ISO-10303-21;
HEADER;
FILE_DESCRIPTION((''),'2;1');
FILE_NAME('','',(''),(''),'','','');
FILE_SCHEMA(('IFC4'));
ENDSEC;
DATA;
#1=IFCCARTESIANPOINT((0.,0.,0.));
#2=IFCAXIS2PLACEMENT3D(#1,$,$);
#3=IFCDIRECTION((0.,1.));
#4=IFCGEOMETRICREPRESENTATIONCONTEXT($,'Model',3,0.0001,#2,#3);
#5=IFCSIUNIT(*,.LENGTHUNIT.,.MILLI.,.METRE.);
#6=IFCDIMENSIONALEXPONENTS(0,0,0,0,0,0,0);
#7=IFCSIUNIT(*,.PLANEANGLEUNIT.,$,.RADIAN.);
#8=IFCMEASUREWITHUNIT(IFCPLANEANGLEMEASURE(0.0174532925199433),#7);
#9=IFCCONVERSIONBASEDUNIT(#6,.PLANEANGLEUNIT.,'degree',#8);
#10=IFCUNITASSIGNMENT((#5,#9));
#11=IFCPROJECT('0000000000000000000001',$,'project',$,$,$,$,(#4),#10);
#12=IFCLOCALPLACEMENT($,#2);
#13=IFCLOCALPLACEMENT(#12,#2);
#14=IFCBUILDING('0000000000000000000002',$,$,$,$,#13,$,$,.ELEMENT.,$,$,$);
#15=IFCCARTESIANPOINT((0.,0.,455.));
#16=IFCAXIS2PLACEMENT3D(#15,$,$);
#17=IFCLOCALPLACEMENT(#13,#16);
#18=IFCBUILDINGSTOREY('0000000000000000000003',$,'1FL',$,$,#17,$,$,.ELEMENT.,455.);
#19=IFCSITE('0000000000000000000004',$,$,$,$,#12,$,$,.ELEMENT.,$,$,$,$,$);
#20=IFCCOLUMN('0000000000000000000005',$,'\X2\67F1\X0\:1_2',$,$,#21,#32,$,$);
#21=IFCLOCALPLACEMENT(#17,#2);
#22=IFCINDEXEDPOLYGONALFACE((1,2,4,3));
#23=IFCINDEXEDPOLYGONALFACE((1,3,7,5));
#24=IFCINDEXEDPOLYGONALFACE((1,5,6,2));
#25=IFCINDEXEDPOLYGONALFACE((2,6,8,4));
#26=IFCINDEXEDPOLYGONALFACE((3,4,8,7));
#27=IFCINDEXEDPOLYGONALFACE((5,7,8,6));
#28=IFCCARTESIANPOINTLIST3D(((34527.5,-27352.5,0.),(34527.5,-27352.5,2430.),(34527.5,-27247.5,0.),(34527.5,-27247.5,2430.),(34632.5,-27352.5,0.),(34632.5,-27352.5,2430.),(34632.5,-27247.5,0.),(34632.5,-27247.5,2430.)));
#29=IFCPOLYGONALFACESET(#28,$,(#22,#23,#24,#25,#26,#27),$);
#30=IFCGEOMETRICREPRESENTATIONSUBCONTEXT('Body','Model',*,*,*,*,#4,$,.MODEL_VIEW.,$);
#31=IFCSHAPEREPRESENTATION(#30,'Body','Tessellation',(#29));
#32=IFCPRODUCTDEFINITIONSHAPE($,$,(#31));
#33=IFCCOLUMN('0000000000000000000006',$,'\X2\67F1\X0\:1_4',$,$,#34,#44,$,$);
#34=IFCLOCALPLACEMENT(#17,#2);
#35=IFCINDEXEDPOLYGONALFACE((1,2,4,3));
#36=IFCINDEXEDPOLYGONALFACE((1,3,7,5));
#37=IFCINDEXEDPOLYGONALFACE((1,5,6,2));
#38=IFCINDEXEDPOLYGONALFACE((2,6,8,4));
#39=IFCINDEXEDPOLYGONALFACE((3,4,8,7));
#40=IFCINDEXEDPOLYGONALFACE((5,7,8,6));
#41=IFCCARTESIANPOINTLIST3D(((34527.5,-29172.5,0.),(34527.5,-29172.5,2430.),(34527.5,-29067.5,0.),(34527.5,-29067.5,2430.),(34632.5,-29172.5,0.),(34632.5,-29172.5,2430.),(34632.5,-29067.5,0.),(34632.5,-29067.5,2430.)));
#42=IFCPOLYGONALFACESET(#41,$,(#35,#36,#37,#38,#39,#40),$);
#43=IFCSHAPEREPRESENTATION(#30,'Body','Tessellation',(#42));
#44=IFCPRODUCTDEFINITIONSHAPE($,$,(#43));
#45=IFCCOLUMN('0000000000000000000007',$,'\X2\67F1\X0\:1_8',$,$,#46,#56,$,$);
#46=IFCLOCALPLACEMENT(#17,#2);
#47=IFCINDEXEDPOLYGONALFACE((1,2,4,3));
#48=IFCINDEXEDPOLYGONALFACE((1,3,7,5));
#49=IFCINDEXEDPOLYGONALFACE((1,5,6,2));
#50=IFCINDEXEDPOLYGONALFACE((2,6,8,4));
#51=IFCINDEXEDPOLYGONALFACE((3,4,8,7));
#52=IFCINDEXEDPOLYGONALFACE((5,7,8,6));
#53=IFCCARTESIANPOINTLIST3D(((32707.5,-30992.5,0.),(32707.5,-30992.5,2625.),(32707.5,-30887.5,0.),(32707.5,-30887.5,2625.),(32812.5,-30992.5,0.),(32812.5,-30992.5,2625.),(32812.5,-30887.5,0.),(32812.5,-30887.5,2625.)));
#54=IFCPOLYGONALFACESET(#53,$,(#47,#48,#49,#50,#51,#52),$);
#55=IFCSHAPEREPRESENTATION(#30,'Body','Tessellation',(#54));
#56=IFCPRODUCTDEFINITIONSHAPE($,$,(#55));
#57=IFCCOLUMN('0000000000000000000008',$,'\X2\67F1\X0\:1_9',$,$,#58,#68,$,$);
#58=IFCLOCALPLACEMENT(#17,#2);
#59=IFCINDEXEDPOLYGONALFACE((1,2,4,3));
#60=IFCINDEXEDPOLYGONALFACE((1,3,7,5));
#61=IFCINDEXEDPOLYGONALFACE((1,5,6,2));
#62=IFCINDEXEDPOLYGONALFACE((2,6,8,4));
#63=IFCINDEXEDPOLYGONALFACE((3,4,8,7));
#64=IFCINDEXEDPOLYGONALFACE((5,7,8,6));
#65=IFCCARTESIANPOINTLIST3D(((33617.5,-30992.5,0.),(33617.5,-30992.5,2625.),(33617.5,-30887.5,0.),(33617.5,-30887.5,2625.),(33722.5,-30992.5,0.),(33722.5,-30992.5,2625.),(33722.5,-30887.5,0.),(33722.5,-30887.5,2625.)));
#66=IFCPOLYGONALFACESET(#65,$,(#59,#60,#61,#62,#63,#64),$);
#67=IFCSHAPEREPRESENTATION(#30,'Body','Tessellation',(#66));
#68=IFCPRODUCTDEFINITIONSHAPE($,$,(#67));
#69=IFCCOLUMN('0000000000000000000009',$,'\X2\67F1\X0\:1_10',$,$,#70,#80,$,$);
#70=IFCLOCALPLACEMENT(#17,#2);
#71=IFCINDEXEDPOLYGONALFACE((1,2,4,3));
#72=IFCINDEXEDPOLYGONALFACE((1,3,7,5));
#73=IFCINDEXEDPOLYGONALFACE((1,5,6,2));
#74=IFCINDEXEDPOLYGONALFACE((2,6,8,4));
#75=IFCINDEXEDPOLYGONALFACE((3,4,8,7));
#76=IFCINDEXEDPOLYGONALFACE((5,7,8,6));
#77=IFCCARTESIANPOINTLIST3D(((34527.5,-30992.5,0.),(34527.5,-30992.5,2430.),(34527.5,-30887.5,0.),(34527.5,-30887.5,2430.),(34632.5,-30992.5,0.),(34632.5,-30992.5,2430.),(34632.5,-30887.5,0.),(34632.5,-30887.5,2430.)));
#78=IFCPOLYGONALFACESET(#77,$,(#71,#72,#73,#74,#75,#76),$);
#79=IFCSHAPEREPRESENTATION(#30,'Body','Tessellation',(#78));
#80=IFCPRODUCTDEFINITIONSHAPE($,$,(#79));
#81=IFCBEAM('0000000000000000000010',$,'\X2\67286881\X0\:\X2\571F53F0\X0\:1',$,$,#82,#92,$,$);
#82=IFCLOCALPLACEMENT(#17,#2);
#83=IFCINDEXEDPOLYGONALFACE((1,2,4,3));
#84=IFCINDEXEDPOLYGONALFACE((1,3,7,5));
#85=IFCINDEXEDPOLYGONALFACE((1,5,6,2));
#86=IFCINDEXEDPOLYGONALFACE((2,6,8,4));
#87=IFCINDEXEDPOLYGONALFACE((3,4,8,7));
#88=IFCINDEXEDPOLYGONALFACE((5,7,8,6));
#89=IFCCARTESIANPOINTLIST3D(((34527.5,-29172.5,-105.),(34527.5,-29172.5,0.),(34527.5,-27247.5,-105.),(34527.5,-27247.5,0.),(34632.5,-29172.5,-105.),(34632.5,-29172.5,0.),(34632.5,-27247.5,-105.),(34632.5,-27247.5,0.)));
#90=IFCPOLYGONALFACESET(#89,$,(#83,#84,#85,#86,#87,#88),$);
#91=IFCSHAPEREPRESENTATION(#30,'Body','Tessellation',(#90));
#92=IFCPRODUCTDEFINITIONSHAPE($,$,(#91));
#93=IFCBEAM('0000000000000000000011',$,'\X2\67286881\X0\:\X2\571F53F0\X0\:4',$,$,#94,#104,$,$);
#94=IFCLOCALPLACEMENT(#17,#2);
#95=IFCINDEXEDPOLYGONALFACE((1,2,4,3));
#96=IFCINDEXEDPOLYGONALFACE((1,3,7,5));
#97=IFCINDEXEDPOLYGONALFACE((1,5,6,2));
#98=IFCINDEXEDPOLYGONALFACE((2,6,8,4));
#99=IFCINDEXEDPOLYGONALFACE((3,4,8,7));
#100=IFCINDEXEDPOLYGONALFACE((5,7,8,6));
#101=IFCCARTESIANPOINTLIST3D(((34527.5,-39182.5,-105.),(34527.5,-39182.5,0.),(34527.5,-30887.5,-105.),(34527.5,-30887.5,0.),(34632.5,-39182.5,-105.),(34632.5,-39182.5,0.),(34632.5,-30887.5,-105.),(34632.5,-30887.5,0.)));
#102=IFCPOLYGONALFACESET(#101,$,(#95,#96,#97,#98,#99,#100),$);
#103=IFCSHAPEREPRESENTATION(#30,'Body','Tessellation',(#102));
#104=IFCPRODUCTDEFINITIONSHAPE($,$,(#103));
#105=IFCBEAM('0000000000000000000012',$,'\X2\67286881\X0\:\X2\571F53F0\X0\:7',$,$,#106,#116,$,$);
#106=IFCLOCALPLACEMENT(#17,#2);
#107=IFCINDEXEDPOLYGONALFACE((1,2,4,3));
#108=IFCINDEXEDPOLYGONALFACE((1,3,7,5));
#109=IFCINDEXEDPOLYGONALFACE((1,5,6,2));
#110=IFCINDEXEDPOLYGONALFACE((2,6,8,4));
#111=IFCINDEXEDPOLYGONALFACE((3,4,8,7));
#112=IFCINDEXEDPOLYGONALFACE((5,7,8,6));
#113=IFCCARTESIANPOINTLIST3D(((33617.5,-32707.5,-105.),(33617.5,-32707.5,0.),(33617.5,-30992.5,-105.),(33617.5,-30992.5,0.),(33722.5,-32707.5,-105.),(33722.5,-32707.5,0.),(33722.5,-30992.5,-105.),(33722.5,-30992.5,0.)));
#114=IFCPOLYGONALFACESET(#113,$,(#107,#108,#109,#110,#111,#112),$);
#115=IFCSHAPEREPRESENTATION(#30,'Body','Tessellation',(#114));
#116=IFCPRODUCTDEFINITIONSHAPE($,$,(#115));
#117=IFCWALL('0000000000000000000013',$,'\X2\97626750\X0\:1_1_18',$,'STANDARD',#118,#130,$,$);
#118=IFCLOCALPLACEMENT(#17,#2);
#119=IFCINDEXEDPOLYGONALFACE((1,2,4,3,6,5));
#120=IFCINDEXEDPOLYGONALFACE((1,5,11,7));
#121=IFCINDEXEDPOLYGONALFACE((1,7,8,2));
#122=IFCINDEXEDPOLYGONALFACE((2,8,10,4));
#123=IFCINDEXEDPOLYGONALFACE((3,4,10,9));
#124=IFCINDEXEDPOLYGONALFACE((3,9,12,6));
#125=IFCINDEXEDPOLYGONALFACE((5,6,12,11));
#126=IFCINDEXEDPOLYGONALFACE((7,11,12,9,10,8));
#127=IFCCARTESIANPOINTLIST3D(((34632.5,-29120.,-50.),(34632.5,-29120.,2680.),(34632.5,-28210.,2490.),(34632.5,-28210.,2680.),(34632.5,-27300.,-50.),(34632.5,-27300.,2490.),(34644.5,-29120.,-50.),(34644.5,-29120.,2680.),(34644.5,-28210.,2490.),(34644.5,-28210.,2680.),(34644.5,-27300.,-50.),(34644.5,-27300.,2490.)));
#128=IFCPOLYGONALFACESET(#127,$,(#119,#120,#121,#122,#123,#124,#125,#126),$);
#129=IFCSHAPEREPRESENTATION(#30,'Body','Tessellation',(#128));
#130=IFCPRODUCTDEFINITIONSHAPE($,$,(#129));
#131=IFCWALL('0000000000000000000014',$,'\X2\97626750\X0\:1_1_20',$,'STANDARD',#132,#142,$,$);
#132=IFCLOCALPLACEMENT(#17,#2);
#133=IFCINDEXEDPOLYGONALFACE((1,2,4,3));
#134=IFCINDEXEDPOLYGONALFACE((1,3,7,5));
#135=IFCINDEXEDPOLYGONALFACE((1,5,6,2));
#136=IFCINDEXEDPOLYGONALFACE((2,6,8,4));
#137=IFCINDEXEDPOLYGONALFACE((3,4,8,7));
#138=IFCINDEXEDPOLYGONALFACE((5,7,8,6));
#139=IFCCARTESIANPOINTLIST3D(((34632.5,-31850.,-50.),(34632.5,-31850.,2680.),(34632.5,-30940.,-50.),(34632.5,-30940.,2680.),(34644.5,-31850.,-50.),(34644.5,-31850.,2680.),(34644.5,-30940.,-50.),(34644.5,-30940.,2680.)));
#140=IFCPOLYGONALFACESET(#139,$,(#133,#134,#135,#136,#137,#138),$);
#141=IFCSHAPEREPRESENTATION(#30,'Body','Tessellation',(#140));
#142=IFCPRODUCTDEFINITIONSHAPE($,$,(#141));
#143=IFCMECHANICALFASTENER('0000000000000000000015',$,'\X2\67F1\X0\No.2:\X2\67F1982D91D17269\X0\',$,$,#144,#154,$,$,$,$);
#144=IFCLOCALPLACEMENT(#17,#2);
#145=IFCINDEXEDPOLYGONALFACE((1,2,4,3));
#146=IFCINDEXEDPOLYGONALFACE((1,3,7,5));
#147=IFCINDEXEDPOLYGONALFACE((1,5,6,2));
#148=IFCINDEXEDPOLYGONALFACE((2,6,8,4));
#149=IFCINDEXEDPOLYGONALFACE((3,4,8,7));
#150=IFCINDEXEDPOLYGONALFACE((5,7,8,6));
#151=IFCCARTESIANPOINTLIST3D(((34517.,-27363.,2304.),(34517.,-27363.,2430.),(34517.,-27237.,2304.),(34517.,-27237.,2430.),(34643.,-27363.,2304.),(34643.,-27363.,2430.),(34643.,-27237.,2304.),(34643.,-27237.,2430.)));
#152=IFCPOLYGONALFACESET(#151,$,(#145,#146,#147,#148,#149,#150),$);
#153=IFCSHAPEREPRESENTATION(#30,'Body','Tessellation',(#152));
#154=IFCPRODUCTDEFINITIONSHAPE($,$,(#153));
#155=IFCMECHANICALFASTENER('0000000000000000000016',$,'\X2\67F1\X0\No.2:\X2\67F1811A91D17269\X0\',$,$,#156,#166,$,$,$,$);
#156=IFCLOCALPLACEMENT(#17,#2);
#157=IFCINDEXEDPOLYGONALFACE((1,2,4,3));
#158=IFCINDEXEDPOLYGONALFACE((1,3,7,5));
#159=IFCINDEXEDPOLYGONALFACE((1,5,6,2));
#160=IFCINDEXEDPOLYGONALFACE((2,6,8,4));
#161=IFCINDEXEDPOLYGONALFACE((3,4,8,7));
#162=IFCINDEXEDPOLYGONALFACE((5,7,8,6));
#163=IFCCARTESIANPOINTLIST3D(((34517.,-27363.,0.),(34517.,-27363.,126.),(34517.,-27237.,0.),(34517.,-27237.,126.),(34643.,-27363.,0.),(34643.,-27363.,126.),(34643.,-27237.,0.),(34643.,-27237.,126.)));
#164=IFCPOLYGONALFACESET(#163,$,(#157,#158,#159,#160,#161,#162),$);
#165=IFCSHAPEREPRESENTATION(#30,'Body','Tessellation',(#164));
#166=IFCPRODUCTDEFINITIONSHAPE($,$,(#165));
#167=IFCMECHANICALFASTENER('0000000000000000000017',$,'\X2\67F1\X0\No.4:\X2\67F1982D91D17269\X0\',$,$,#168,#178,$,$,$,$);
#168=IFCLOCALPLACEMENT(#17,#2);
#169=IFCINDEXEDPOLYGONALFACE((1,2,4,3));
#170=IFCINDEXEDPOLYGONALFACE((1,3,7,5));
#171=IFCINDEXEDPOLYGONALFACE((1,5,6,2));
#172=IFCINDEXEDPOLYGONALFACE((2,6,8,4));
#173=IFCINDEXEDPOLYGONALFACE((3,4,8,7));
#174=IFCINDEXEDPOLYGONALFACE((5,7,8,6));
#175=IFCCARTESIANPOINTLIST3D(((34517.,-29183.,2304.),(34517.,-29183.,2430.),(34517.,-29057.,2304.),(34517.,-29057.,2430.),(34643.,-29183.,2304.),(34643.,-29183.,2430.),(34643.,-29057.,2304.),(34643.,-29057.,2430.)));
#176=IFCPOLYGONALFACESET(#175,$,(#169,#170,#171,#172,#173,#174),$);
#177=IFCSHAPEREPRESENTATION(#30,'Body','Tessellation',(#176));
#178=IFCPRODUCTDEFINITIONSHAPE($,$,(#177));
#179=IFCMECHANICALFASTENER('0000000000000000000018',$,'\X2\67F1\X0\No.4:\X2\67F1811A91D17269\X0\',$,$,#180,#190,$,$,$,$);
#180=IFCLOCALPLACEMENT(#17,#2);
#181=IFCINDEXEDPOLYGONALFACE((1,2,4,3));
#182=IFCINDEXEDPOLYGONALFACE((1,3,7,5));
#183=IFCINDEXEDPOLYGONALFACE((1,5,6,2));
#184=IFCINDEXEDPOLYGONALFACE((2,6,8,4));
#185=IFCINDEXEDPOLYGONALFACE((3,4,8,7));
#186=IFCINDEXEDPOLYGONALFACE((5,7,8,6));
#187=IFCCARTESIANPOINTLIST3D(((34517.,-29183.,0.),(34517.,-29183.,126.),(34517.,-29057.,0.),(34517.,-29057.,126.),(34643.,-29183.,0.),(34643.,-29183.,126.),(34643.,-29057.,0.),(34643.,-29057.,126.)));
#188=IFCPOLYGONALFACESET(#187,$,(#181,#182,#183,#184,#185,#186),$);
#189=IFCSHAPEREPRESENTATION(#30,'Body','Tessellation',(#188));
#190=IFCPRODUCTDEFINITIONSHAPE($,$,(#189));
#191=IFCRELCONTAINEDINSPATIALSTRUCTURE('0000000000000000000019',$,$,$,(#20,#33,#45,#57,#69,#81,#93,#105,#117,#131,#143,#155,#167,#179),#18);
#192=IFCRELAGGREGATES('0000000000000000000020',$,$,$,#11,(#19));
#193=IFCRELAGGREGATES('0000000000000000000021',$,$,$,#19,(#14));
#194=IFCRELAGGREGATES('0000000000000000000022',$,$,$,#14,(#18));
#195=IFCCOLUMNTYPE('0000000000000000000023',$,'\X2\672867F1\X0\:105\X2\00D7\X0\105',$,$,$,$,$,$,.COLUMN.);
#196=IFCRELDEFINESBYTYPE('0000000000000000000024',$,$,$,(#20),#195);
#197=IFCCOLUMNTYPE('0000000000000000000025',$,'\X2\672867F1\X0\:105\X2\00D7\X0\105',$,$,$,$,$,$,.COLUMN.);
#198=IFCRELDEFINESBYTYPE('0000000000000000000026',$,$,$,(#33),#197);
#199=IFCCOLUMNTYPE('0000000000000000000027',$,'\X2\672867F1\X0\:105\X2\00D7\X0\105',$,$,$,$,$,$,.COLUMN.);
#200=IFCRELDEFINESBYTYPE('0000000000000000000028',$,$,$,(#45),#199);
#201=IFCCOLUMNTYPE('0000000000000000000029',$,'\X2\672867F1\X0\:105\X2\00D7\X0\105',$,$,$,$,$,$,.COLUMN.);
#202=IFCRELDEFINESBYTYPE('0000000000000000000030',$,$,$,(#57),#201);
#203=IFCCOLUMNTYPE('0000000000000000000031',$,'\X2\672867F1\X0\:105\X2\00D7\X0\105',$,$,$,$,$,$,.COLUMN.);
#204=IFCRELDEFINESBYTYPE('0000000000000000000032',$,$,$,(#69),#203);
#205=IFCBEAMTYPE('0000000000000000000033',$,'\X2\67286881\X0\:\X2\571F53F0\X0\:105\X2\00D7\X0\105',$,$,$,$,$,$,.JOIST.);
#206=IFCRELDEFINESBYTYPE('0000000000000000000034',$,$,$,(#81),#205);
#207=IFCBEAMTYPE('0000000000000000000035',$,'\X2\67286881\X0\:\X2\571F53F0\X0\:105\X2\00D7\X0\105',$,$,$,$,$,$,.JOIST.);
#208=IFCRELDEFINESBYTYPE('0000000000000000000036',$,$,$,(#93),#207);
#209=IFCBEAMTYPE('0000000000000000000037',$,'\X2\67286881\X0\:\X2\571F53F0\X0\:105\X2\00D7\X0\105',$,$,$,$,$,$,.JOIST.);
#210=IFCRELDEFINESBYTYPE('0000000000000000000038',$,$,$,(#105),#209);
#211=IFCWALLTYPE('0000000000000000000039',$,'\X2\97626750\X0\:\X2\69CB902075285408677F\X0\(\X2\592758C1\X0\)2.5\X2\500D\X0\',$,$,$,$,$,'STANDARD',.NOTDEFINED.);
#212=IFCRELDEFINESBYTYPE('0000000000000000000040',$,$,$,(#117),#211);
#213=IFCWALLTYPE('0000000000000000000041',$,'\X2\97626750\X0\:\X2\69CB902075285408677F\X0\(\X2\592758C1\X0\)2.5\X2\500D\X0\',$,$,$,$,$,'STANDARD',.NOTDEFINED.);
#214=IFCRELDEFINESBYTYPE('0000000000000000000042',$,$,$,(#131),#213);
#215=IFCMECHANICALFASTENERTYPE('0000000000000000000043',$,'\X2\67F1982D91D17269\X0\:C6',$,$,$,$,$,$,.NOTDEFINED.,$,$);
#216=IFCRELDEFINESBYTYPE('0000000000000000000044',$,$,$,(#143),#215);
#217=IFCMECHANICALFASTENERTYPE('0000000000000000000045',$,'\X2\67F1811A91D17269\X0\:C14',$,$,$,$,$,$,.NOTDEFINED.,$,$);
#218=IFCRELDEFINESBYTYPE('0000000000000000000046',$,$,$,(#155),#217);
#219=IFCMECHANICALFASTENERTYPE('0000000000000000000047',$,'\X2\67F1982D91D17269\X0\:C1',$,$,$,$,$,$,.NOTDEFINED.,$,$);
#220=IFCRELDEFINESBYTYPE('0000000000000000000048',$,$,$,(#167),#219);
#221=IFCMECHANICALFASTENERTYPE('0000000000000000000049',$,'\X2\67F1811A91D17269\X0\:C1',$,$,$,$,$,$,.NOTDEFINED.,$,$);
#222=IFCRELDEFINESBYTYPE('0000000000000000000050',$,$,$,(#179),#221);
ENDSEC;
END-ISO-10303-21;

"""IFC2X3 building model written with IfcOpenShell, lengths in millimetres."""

from ifc_helpers import new_model, entity, si_unit, converted_unit, direction, frame, origin, origin_with_axes, origin_2d, place, context, subcontext, project, spatial, polyline, rectangle, outline, extrude, type_object, element, save


model = new_model("IFC2X3")

# Units and contexts
model_context = context("Model", 3, precision=0.0001, world=origin(), true_north=direction((0.0, 1.0)))
body_context = subcontext(model_context, "Body", "Model", "MODEL_VIEW")
ifc_project = project(units=[si_unit("LENGTHUNIT", "METRE", prefix="MILLI"), converted_unit("PLANEANGLEUNIT", "degree", entity("IfcPlaneAngleMeasure", 0.0174532925199433), si_unit("PLANEANGLEUNIT", "RADIAN"), dimensions=[0, 0, 0, 0, 0, 0, 0])], contexts=[model_context])

# Site, building, storey
site_placement = place(None, origin())
site = spatial("IfcSite", under=ifc_project, at=site_placement, CompositionType="ELEMENT")
building_placement = place(site_placement, origin())
building = spatial("IfcBuilding", under=site, at=building_placement, CompositionType="ELEMENT")
storey_placement = place(building_placement, frame((0.0, 0.0, 455.0)))
storey = spatial("IfcBuildingStorey", under=building, at=storey_placement, Name="1FL", CompositionType="ELEMENT", Elevation=455.0)

# Columns
column_type_1 = type_object("IfcColumnType", Name="木柱:105×105", PredefinedType="COLUMN")
column_1_placement = place(storey_placement, frame((34580.0, -27300.0, 0.0)))
element("IfcColumn", 1, at=column_1_placement, inside=storey, type_object=column_type_1, Name="柱:1_2", context=body_context, shape_type="SweptSolid", body=[
    extrude(rectangle(XDim=105.0, YDim=105.0, at=origin_2d()), origin_with_axes(), (0.0, 0.0, 1.0), 2430.0),
])
column_type_2 = type_object("IfcColumnType", Name="木柱:105×105", PredefinedType="COLUMN")
column_2_placement = place(storey_placement, frame((34580.0, -29120.0, 0.0)))
element("IfcColumn", 2, at=column_2_placement, inside=storey, type_object=column_type_2, Name="柱:1_4", context=body_context, shape_type="SweptSolid", body=[
    extrude(rectangle(XDim=105.0, YDim=105.0, at=origin_2d()), origin_with_axes(), (0.0, 0.0, 1.0), 2430.0),
])
column_type_3 = type_object("IfcColumnType", Name="木柱:105×105", PredefinedType="COLUMN")
column_3_placement = place(storey_placement, frame((32760.0, -30940.0, 0.0)))
element("IfcColumn", 3, at=column_3_placement, inside=storey, type_object=column_type_3, Name="柱:1_8", context=body_context, shape_type="SweptSolid", body=[
    extrude(rectangle(XDim=105.0, YDim=105.0, at=origin_2d()), origin_with_axes(), (0.0, 0.0, 1.0), 2625.0),
])
column_type_4 = type_object("IfcColumnType", Name="木柱:105×105", PredefinedType="COLUMN")
column_4_placement = place(storey_placement, frame((33670.0, -30940.0, 0.0)))
element("IfcColumn", 4, at=column_4_placement, inside=storey, type_object=column_type_4, Name="柱:1_9", context=body_context, shape_type="SweptSolid", body=[
    extrude(rectangle(XDim=105.0, YDim=105.0, at=origin_2d()), origin_with_axes(), (0.0, 0.0, 1.0), 2625.0),
])
column_type_5 = type_object("IfcColumnType", Name="木柱:105×105", PredefinedType="COLUMN")
column_5_placement = place(storey_placement, frame((34580.0, -30940.0, 0.0)))
element("IfcColumn", 5, at=column_5_placement, inside=storey, type_object=column_type_5, Name="柱:1_10", context=body_context, shape_type="SweptSolid", body=[
    extrude(rectangle(XDim=105.0, YDim=105.0, at=origin_2d()), origin_with_axes(), (0.0, 0.0, 1.0), 2430.0),
])

# Beams
beam_type_1 = type_object("IfcBeamType", Name="木梁:土台:105×105", PredefinedType="JOIST")
beam_1_placement = place(storey_placement, frame((34580.0, -27247.5, -52.5), z_axis=(0.0, -1.0, 0.0), x_axis=(1.0, 0.0, 0.0)))
element("IfcBeam", 6, at=beam_1_placement, inside=storey, type_object=beam_type_1, Name="木梁:土台:1", context=body_context, shape_type="SweptSolid", body=[
    extrude(rectangle(XDim=105.0, YDim=105.0, at=origin_2d()), origin_with_axes(), (0.0, 0.0, 1.0), 1925.0),
])
beam_type_2 = type_object("IfcBeamType", Name="木梁:土台:105×105", PredefinedType="JOIST")
beam_2_placement = place(storey_placement, frame((34580.0, -30887.5, -52.5), z_axis=(0.0, -1.0, 0.0), x_axis=(1.0, 0.0, 0.0)))
element("IfcBeam", 7, at=beam_2_placement, inside=storey, type_object=beam_type_2, Name="木梁:土台:4", context=body_context, shape_type="SweptSolid", body=[
    extrude(rectangle(XDim=105.0, YDim=105.0, at=origin_2d()), origin_with_axes(), (0.0, 0.0, 1.0), 8295.0),
])
beam_type_3 = type_object("IfcBeamType", Name="木梁:土台:105×105", PredefinedType="JOIST")
beam_3_placement = place(storey_placement, frame((33670.0, -30992.5, -52.5), z_axis=(0.0, -1.0, 0.0), x_axis=(1.0, 0.0, 0.0)))
element("IfcBeam", 8, at=beam_3_placement, inside=storey, type_object=beam_type_3, Name="木梁:土台:7", context=body_context, shape_type="SweptSolid", body=[
    extrude(rectangle(XDim=105.0, YDim=105.0, at=origin_2d()), origin_with_axes(), (0.0, 0.0, 1.0), 1715.0),
])

# Walls
wall_type_1 = type_object("IfcWallType", Name="面材:構造用合板(大壁)2.5倍", ElementType="STANDARD", PredefinedType="NOTDEFINED")
wall_1_placement = place(storey_placement, frame((34644.5, -28210.0, -50.0), z_axis=(-1.0, 0.0, 0.0), x_axis=(0.0, -1.0, 0.0)))
element("IfcWall", 9, at=wall_1_placement, inside=storey, type_object=wall_type_1, Name="面材:1_1_18", ObjectType="STANDARD", context=body_context, shape_type="SweptSolid", body=[
    extrude(outline(polyline([(910.0, 0.0, 0.0), (-910.0, 0.0, 0.0), (-910.0, 2540.0, 0.0), (0.0, 2540.0, 0.0), (0.0, 2730.0, 0.0), (910.0, 2730.0, 0.0), (910.0, 0.0, 0.0)])), origin_with_axes(), (0.0, 0.0, 1.0), 12.0),
])
wall_type_2 = type_object("IfcWallType", Name="面材:構造用合板(大壁)2.5倍", ElementType="STANDARD", PredefinedType="NOTDEFINED")
wall_2_placement = place(storey_placement, frame((34644.5, -31395.0, -50.0), z_axis=(-1.0, 0.0, 0.0), x_axis=(0.0, -1.0, 0.0)))
element("IfcWall", 10, at=wall_2_placement, inside=storey, type_object=wall_type_2, Name="面材:1_1_20", ObjectType="STANDARD", context=body_context, shape_type="SweptSolid", body=[
    extrude(outline(polyline([(455.0, 0.0, 0.0), (-455.0, 0.0, 0.0), (-455.0, 2730.0, 0.0), (455.0, 2730.0, 0.0), (455.0, 0.0, 0.0)])), origin_with_axes(), (0.0, 0.0, 1.0), 12.0),
])

# Mechanical fasteners
mechanical_fastener_type_1 = type_object("IfcMechanicalFastenerType", Name="柱頭金物:C6")
mechanical_fastener_1_placement = place(storey_placement, frame((34580.0, -27300.0, 2304.0)))
element("IfcMechanicalFastener", 11, at=mechanical_fastener_1_placement, inside=storey, type_object=mechanical_fastener_type_1, Name="柱No.2:柱頭金物", context=body_context, shape_type="SweptSolid", body=[
    extrude(rectangle(XDim=126.0, YDim=126.0, at=origin_2d()), origin_with_axes(), (0.0, 0.0, 1.0), 126.0),
])
mechanical_fastener_type_2 = type_object("IfcMechanicalFastenerType", Name="柱脚金物:C14")
mechanical_fastener_2_placement = place(storey_placement, frame((34580.0, -27300.0, 0.0)))
element("IfcMechanicalFastener", 12, at=mechanical_fastener_2_placement, inside=storey, type_object=mechanical_fastener_type_2, Name="柱No.2:柱脚金物", context=body_context, shape_type="SweptSolid", body=[
    extrude(rectangle(XDim=126.0, YDim=126.0, at=origin_2d()), origin_with_axes(), (0.0, 0.0, 1.0), 126.0),
])
mechanical_fastener_type_3 = type_object("IfcMechanicalFastenerType", Name="柱頭金物:C1")
mechanical_fastener_3_placement = place(storey_placement, frame((34580.0, -29120.0, 2304.0)))
element("IfcMechanicalFastener", 13, at=mechanical_fastener_3_placement, inside=storey, type_object=mechanical_fastener_type_3, Name="柱No.4:柱頭金物", context=body_context, shape_type="SweptSolid", body=[
    extrude(rectangle(XDim=126.0, YDim=126.0, at=origin_2d()), origin_with_axes(), (0.0, 0.0, 1.0), 126.0),
])
mechanical_fastener_type_4 = type_object("IfcMechanicalFastenerType", Name="柱脚金物:C1")
mechanical_fastener_4_placement = place(storey_placement, frame((34580.0, -29120.0, 0.0)))
element("IfcMechanicalFastener", 14, at=mechanical_fastener_4_placement, inside=storey, type_object=mechanical_fastener_type_4, Name="柱No.4:柱脚金物", context=body_context, shape_type="SweptSolid", body=[
    extrude(rectangle(XDim=126.0, YDim=126.0, at=origin_2d()), origin_with_axes(), (0.0, 0.0, 1.0), 126.0),
])

save(model, "model.ifc")
